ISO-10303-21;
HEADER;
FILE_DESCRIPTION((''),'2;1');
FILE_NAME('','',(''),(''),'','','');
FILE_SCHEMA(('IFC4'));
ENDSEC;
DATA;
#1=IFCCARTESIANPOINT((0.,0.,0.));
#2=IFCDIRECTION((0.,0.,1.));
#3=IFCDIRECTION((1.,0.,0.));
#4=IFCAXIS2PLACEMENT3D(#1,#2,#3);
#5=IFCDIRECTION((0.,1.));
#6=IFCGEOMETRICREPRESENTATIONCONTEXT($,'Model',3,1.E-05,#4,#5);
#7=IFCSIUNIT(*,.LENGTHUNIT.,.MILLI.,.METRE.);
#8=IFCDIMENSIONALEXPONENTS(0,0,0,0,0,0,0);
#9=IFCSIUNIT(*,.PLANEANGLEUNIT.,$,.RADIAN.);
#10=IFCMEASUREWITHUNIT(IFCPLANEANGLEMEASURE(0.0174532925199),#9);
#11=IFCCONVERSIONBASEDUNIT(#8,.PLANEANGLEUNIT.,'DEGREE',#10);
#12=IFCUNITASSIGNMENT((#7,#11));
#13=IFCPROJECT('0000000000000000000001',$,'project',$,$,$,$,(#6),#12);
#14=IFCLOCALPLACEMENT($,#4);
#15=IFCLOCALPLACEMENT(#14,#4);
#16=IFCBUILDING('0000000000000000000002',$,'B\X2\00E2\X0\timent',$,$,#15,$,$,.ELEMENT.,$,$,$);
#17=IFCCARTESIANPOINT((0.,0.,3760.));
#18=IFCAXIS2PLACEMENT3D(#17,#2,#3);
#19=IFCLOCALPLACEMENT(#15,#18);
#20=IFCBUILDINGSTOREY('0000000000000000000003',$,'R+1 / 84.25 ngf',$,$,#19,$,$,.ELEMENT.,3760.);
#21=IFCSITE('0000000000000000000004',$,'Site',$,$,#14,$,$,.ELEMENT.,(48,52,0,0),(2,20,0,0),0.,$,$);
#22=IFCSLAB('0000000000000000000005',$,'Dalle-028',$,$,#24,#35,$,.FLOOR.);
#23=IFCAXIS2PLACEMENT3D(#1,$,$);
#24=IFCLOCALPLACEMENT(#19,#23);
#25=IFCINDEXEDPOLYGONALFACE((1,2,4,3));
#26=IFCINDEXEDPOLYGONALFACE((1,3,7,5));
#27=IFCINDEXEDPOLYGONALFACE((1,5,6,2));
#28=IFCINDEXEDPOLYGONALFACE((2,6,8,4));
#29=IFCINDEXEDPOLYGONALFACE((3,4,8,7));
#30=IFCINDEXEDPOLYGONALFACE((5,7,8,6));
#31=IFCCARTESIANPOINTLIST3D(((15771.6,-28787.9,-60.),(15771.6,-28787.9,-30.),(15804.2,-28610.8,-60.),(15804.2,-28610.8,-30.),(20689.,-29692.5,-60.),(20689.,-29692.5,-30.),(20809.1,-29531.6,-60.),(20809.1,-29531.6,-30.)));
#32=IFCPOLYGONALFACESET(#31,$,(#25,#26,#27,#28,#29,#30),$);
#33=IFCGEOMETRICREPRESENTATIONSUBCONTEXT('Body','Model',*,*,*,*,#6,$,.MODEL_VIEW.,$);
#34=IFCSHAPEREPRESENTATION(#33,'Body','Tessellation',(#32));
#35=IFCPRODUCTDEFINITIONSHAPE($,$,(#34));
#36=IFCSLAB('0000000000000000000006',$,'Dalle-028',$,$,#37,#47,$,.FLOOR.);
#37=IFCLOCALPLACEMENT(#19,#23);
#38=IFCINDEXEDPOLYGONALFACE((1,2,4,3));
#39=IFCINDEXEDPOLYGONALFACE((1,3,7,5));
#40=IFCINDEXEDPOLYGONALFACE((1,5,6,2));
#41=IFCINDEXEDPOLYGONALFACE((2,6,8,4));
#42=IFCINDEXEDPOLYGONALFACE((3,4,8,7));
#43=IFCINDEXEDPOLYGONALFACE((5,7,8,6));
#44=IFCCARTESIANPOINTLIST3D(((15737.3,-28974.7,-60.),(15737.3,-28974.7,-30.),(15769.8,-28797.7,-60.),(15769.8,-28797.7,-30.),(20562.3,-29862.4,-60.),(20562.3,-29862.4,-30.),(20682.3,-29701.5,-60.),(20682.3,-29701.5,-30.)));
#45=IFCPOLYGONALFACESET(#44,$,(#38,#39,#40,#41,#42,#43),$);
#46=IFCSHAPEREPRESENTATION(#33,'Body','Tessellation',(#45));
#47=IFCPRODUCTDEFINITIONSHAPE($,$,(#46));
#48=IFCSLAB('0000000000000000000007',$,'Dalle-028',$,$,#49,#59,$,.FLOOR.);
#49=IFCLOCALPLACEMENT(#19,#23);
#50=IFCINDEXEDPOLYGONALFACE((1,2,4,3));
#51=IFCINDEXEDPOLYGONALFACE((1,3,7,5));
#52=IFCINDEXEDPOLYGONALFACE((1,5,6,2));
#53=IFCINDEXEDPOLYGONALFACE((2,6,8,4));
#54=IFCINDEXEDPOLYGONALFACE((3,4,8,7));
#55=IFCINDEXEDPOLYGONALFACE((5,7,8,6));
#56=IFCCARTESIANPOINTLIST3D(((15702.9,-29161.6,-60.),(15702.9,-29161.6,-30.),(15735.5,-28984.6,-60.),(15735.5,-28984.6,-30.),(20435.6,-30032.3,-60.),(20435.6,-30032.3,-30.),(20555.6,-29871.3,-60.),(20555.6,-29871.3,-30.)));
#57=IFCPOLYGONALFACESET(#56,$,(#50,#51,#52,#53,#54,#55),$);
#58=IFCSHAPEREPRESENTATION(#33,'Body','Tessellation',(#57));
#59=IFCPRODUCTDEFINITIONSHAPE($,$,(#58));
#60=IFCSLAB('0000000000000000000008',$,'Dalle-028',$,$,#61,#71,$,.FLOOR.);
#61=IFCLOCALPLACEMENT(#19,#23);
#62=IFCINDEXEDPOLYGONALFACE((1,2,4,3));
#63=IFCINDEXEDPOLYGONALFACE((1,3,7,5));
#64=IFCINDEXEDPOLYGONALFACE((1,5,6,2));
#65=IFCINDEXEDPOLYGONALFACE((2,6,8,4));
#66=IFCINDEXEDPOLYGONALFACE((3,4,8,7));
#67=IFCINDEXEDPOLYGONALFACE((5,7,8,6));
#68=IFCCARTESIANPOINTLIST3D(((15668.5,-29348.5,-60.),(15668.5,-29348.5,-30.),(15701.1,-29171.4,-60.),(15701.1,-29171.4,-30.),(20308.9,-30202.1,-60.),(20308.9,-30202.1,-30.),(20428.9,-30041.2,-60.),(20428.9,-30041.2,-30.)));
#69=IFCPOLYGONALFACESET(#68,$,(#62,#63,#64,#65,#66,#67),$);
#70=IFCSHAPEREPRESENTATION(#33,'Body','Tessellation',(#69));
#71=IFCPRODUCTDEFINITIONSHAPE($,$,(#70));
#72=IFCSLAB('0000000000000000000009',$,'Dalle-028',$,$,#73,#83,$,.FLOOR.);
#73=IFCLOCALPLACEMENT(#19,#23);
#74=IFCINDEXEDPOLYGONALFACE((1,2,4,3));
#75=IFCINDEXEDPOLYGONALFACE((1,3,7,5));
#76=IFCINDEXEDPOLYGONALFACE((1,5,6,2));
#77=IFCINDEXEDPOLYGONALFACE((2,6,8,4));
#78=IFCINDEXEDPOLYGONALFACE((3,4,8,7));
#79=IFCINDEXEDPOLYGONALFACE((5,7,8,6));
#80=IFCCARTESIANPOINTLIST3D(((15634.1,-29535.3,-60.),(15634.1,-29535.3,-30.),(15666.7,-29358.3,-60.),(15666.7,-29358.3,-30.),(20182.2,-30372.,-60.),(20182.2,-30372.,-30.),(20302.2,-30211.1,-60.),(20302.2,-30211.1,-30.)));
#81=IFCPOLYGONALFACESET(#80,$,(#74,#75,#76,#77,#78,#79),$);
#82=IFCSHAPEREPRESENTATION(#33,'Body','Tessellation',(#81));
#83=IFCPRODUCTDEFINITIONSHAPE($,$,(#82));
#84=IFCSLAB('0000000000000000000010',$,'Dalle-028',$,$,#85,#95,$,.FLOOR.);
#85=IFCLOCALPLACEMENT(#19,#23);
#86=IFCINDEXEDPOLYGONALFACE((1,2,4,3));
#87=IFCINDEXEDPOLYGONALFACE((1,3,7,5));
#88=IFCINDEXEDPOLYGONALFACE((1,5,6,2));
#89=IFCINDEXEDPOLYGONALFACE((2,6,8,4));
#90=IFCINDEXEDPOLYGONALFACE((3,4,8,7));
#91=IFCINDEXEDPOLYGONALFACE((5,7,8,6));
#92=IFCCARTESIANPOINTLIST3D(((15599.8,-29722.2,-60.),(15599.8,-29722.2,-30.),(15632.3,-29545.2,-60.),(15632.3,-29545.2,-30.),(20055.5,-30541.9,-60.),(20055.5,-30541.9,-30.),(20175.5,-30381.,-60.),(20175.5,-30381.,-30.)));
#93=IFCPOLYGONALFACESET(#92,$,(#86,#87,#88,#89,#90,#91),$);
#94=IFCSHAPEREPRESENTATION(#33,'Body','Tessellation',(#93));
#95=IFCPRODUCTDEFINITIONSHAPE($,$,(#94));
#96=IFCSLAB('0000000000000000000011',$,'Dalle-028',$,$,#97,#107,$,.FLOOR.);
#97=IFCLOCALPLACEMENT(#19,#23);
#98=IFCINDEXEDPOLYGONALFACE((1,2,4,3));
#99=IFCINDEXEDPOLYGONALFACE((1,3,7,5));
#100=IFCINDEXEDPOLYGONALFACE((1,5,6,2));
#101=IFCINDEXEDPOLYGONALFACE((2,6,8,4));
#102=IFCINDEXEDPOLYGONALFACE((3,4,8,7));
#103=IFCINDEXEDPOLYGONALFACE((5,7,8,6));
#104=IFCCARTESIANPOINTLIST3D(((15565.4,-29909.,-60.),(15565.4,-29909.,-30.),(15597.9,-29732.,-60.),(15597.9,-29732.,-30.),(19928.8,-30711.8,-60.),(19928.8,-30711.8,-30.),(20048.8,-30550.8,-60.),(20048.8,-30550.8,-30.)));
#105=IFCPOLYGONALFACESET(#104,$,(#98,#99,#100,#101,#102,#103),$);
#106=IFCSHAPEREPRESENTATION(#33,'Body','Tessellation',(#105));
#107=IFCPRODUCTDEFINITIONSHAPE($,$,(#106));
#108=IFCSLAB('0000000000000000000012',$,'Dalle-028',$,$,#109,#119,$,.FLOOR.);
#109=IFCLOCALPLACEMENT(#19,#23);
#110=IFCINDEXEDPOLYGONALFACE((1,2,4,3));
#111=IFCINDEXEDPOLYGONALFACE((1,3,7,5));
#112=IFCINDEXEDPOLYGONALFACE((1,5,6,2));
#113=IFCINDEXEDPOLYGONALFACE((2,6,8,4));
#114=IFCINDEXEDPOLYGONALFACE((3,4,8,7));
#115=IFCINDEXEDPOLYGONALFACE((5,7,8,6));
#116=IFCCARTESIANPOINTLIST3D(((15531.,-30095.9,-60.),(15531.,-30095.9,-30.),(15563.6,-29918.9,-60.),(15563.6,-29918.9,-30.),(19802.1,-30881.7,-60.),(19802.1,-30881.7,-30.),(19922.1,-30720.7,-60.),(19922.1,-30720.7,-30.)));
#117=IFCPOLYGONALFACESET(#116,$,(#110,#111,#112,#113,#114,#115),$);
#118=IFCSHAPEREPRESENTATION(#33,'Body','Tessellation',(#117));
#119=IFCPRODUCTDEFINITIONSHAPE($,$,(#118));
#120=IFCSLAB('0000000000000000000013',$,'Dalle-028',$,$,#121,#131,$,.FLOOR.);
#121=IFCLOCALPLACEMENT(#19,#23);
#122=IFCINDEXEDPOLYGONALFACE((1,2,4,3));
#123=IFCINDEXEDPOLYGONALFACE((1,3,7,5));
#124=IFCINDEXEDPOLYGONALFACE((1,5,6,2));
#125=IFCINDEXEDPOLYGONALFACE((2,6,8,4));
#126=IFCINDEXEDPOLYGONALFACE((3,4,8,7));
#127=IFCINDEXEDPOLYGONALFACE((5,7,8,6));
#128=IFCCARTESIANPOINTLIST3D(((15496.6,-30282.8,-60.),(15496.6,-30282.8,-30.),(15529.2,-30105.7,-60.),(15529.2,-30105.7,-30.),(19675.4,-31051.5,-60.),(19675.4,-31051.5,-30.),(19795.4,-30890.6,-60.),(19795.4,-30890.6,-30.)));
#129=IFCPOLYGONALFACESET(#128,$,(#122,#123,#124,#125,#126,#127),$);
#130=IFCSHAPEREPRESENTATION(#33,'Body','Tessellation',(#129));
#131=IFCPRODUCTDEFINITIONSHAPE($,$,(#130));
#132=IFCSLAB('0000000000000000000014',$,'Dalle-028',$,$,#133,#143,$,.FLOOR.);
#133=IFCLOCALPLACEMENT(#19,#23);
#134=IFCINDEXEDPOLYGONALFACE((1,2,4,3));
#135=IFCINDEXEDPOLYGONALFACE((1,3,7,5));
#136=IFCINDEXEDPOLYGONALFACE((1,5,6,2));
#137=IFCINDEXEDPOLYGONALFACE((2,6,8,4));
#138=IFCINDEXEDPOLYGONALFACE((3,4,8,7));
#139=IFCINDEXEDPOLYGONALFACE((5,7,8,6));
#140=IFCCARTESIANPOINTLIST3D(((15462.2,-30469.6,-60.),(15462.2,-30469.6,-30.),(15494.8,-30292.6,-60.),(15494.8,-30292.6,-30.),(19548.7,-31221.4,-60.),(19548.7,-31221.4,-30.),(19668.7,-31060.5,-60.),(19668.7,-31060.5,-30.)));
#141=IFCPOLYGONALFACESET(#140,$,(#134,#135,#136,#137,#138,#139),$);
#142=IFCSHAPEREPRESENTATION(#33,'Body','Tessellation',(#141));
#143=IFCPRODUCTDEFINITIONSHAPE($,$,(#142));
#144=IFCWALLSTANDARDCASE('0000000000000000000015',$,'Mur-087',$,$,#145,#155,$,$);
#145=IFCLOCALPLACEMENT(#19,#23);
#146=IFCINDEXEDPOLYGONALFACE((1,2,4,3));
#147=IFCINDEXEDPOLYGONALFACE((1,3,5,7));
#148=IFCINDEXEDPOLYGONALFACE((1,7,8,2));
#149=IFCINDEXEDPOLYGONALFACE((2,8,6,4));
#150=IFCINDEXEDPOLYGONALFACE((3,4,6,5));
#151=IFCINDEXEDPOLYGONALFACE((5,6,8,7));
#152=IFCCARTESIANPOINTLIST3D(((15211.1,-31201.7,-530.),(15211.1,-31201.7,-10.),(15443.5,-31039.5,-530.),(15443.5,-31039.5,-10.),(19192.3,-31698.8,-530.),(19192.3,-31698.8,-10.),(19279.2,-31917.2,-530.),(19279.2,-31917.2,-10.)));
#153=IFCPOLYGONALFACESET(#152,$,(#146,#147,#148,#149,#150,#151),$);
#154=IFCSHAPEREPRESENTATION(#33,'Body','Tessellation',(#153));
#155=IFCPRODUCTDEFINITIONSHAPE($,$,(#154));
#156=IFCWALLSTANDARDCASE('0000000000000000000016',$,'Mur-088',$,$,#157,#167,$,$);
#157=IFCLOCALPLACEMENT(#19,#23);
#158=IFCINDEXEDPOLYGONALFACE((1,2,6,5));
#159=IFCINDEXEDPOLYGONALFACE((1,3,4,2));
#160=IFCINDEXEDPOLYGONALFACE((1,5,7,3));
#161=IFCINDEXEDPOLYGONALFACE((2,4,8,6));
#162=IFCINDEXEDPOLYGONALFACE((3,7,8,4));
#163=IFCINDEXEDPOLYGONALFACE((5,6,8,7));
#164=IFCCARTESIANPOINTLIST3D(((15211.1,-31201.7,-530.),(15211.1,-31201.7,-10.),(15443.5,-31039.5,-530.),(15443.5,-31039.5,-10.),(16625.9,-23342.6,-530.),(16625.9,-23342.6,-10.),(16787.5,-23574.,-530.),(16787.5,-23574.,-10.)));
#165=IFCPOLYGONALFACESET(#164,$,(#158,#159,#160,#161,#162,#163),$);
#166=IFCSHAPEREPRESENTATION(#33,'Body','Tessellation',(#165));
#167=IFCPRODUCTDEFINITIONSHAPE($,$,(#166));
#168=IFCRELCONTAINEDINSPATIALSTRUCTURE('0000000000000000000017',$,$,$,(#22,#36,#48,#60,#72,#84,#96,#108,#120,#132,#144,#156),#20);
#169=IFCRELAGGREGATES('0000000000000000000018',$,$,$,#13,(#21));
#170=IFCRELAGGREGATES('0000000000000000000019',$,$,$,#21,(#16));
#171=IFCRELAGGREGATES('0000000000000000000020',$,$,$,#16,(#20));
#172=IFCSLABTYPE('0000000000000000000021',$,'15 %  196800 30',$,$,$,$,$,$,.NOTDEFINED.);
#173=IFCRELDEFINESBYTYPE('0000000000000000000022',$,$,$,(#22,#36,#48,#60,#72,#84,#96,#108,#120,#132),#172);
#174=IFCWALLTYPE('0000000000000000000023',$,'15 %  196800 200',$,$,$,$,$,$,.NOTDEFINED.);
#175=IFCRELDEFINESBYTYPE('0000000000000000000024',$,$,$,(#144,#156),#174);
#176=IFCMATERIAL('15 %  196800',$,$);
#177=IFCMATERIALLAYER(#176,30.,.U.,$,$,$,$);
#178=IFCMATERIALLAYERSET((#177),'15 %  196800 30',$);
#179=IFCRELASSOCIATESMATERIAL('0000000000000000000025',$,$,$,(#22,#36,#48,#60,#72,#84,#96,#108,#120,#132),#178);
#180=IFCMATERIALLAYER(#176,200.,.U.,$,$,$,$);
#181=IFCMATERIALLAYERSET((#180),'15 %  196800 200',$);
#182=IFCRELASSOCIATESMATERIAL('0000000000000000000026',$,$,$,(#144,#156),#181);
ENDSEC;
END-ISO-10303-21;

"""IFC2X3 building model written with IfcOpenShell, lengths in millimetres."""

from ifc_helpers import new_model, entity, si_unit, converted_unit, direction, frame, origin_with_axes, place, context, subcontext, project, spatial, polyline, outline, extrude, material, layer, layer_set, layer_usage, type_object, element, save


model = new_model("IFC2X3")

# Units and contexts
model_context = context("Model", 3, precision=1e-05, world=origin_with_axes(), true_north=direction((0.0, 1.0)))
body_context = subcontext(model_context, "Body", "Model", "MODEL_VIEW")
ifc_project = project(units=[si_unit("LENGTHUNIT", "METRE", prefix="MILLI"), converted_unit("PLANEANGLEUNIT", "DEGREE", entity("IfcPlaneAngleMeasure", 0.0174532925199), si_unit("PLANEANGLEUNIT", "RADIAN"), dimensions=[0, 0, 0, 0, 0, 0, 0])], contexts=[model_context])

# Site, building, storey
site_placement = place(None, origin_with_axes())
site = spatial("IfcSite", under=ifc_project, at=site_placement, Name="Site", CompositionType="ELEMENT", RefLatitude=(48, 52, 0, 0), RefLongitude=(2, 20, 0, 0), RefElevation=0.0)
building_placement = place(site_placement, origin_with_axes())
building = spatial("IfcBuilding", under=site, at=building_placement, Name="Bâtiment", CompositionType="ELEMENT")
storey_placement = place(building_placement, frame((0.0, 0.0, 3760.0), z_axis=(0.0, 0.0, 1.0), x_axis=(1.0, 0.0, 0.0)))
storey = spatial("IfcBuildingStorey", under=building, at=storey_placement, Name="R+1 / 84.25 ngf", CompositionType="ELEMENT", Elevation=3760.0)

# Slabs
ifc_material_1 = material(Name="15 %  196800")
ifc_layer_1 = layer(ifc_material_1, 30.0, ventilated="UNKNOWN")
ifc_layer_set_1 = layer_set([ifc_layer_1], Name="15 %  196800 30")
slab_type = type_object("IfcSlabType", Name="15 %  196800 30", PredefinedType="NOTDEFINED")
ifc_layer_usage_1 = layer_usage(ifc_layer_set_1, "AXIS3", "NEGATIVE", 30.0)
slab_1_placement = place(storey_placement, frame((15804.2, -28610.8, -30.0), z_axis=(0.0, 0.0, 1.0), x_axis=(1.0, 0.0, 0.0)))
element("IfcSlab", 1, at=slab_1_placement, inside=storey, type_object=slab_type, material=ifc_layer_usage_1, Name="Dalle-028", PredefinedType="FLOOR", context=body_context, shape_type="SweptSolid", body=[
    extrude(outline(polyline([(0.0, 0.0), (-32.6, -177.0), (4884.8, -1081.7), (5004.8, -920.7), (0.0, 0.0)])), frame((0.0, 0.0, -30.0), z_axis=(0.0, 0.0, 1.0), x_axis=(1.0, 0.0, 0.0)), (0.0, 0.0, 1.0), 30.0),
])
ifc_layer_usage_2 = layer_usage(ifc_layer_set_1, "AXIS3", "NEGATIVE", 30.0)
slab_2_placement = place(storey_placement, frame((15769.8, -28797.7, -30.0), z_axis=(0.0, 0.0, 1.0), x_axis=(1.0, 0.0, 0.0)))
element("IfcSlab", 2, at=slab_2_placement, inside=storey, type_object=slab_type, material=ifc_layer_usage_2, Name="Dalle-028", PredefinedType="FLOOR", context=body_context, shape_type="SweptSolid", body=[
    extrude(outline(polyline([(0.0, 0.0), (-32.6, -177.0), (4792.5, -1064.7), (4912.5, -903.8), (0.0, 0.0)])), frame((0.0, 0.0, -30.0), z_axis=(0.0, 0.0, 1.0), x_axis=(1.0, 0.0, 0.0)), (0.0, 0.0, 1.0), 30.0),
])
ifc_layer_usage_3 = layer_usage(ifc_layer_set_1, "AXIS3", "NEGATIVE", 30.0)
slab_3_placement = place(storey_placement, frame((15735.5, -28984.6, -30.0), z_axis=(0.0, 0.0, 1.0), x_axis=(1.0, 0.0, 0.0)))
element("IfcSlab", 3, at=slab_3_placement, inside=storey, type_object=slab_type, material=ifc_layer_usage_3, Name="Dalle-028", PredefinedType="FLOOR", context=body_context, shape_type="SweptSolid", body=[
    extrude(outline(polyline([(0.0, 0.0), (-32.6, -177.0), (4700.1, -1047.7), (4820.2, -886.8), (0.0, 0.0)])), frame((0.0, 0.0, -30.0), z_axis=(0.0, 0.0, 1.0), x_axis=(1.0, 0.0, 0.0)), (0.0, 0.0, 1.0), 30.0),
])
ifc_layer_usage_4 = layer_usage(ifc_layer_set_1, "AXIS3", "NEGATIVE", 30.0)
slab_4_placement = place(storey_placement, frame((15701.1, -29171.4, -30.0), z_axis=(0.0, 0.0, 1.0), x_axis=(1.0, 0.0, 0.0)))
element("IfcSlab", 4, at=slab_4_placement, inside=storey, type_object=slab_type, material=ifc_layer_usage_4, Name="Dalle-028", PredefinedType="FLOOR", context=body_context, shape_type="SweptSolid", body=[
    extrude(outline(polyline([(0.0, 0.0), (-32.6, -177.0), (4607.8, -1030.7), (4727.9, -869.8), (0.0, 0.0)])), frame((0.0, 0.0, -30.0), z_axis=(0.0, 0.0, 1.0), x_axis=(1.0, 0.0, 0.0)), (0.0, 0.0, 1.0), 30.0),
])
ifc_layer_usage_5 = layer_usage(ifc_layer_set_1, "AXIS3", "NEGATIVE", 30.0)
slab_5_placement = place(storey_placement, frame((15666.7, -29358.3, -30.0), z_axis=(0.0, 0.0, 1.0), x_axis=(1.0, 0.0, 0.0)))
element("IfcSlab", 5, at=slab_5_placement, inside=storey, type_object=slab_type, material=ifc_layer_usage_5, Name="Dalle-028", PredefinedType="FLOOR", context=body_context, shape_type="SweptSolid", body=[
    extrude(outline(polyline([(0.0, 0.0), (-32.6, -177.0), (4515.5, -1013.7), (4635.5, -852.8), (0.0, 0.0)])), frame((0.0, 0.0, -30.0), z_axis=(0.0, 0.0, 1.0), x_axis=(1.0, 0.0, 0.0)), (0.0, 0.0, 1.0), 30.0),
])
ifc_layer_usage_6 = layer_usage(ifc_layer_set_1, "AXIS3", "NEGATIVE", 30.0)
slab_6_placement = place(storey_placement, frame((15632.3, -29545.2, -30.0), z_axis=(0.0, 0.0, 1.0), x_axis=(1.0, 0.0, 0.0)))
element("IfcSlab", 6, at=slab_6_placement, inside=storey, type_object=slab_type, material=ifc_layer_usage_6, Name="Dalle-028", PredefinedType="FLOOR", context=body_context, shape_type="SweptSolid", body=[
    extrude(outline(polyline([(0.0, 0.0), (-32.6, -177.0), (4423.2, -996.7), (4543.2, -835.8), (0.0, 0.0)])), frame((0.0, 0.0, -30.0), z_axis=(0.0, 0.0, 1.0), x_axis=(1.0, 0.0, 0.0)), (0.0, 0.0, 1.0), 30.0),
])
ifc_layer_usage_7 = layer_usage(ifc_layer_set_1, "AXIS3", "NEGATIVE", 30.0)
slab_7_placement = place(storey_placement, frame((15597.9, -29732.0, -30.0), z_axis=(0.0, 0.0, 1.0), x_axis=(1.0, 0.0, 0.0)))
element("IfcSlab", 7, at=slab_7_placement, inside=storey, type_object=slab_type, material=ifc_layer_usage_7, Name="Dalle-028", PredefinedType="FLOOR", context=body_context, shape_type="SweptSolid", body=[
    extrude(outline(polyline([(0.0, 0.0), (-32.6, -177.0), (4330.8, -979.8), (4450.9, -818.8), (0.0, 0.0)])), frame((0.0, 0.0, -30.0), z_axis=(0.0, 0.0, 1.0), x_axis=(1.0, 0.0, 0.0)), (0.0, 0.0, 1.0), 30.0),
])
ifc_layer_usage_8 = layer_usage(ifc_layer_set_1, "AXIS3", "NEGATIVE", 30.0)
slab_8_placement = place(storey_placement, frame((15563.6, -29918.9, -30.0), z_axis=(0.0, 0.0, 1.0), x_axis=(1.0, 0.0, 0.0)))
element("IfcSlab", 8, at=slab_8_placement, inside=storey, type_object=slab_type, material=ifc_layer_usage_8, Name="Dalle-028", PredefinedType="FLOOR", context=body_context, shape_type="SweptSolid", body=[
    extrude(outline(polyline([(0.0, 0.0), (-32.6, -177.0), (4238.5, -962.8), (4358.5, -801.8), (0.0, 0.0)])), frame((0.0, 0.0, -30.0), z_axis=(0.0, 0.0, 1.0), x_axis=(1.0, 0.0, 0.0)), (0.0, 0.0, 1.0), 30.0),
])
ifc_layer_usage_9 = layer_usage(ifc_layer_set_1, "AXIS3", "NEGATIVE", 30.0)
slab_9_placement = place(storey_placement, frame((15529.2, -30105.7, -30.0), z_axis=(0.0, 0.0, 1.0), x_axis=(1.0, 0.0, 0.0)))
element("IfcSlab", 9, at=slab_9_placement, inside=storey, type_object=slab_type, material=ifc_layer_usage_9, Name="Dalle-028", PredefinedType="FLOOR", context=body_context, shape_type="SweptSolid", body=[
    extrude(outline(polyline([(0.0, 0.0), (-32.6, -177.0), (4146.2, -945.8), (4266.2, -784.8), (0.0, 0.0)])), frame((0.0, 0.0, -30.0), z_axis=(0.0, 0.0, 1.0), x_axis=(1.0, 0.0, 0.0)), (0.0, 0.0, 1.0), 30.0),
])
ifc_layer_usage_10 = layer_usage(ifc_layer_set_1, "AXIS3", "NEGATIVE", 30.0)
slab_10_placement = place(storey_placement, frame((15494.8, -30292.6, -30.0), z_axis=(0.0, 0.0, 1.0), x_axis=(1.0, 0.0, 0.0)))
element("IfcSlab", 10, at=slab_10_placement, inside=storey, type_object=slab_type, material=ifc_layer_usage_10, Name="Dalle-028", PredefinedType="FLOOR", context=body_context, shape_type="SweptSolid", body=[
    extrude(outline(polyline([(0.0, 0.0), (-32.6, -177.0), (4053.8, -928.8), (4173.9, -767.9), (0.0, 0.0)])), frame((0.0, 0.0, -30.0), z_axis=(0.0, 0.0, 1.0), x_axis=(1.0, 0.0, 0.0)), (0.0, 0.0, 1.0), 30.0),
])

# Walls
ifc_layer_2 = layer(ifc_material_1, 200.0, ventilated="UNKNOWN")
ifc_layer_set_2 = layer_set([ifc_layer_2], Name="15 %  196800 200")
ifc_layer_usage_11 = layer_usage(ifc_layer_set_2, "AXIS2", "POSITIVE", -200.0)
wall_type = type_object("IfcWallType", Name="15 %  196800 200", PredefinedType="NOTDEFINED")
wall_1_placement = place(storey_placement, frame((19279.2, -31917.2, -530.0), z_axis=(0.0, 0.0, 1.0), x_axis=(-0.984885, 0.173208, 0.0)))
element("IfcWallStandardCase", 11, at=wall_1_placement, inside=storey, type_object=wall_type, material=ifc_layer_usage_11, Name="Mur-087", context=body_context, shape_type="SweptSolid", body=[
    extrude(outline(polyline([(123.4, -200.0), (3929.7, -200.0), (4130.5, 0.0), (0.0, 0.0), (123.4, -200.0)])), origin_with_axes(), (0.0, 0.0, 1.0), 520.0),
])
ifc_layer_usage_12 = layer_usage(ifc_layer_set_2, "AXIS2", "POSITIVE", -200.0)
wall_2_placement = place(storey_placement, frame((15211.1, -31201.7, -530.0), z_axis=(0.0, 0.0, 1.0), x_axis=(0.177175, 0.984179, 0.0)))
element("IfcWallStandardCase", 12, at=wall_2_placement, inside=storey, type_object=wall_type, material=ifc_layer_usage_12, Name="Mur-088", context=body_context, shape_type="SweptSolid", body=[
    extrude(outline(polyline([(200.8, -200.0), (7786.3, -200.0), (7985.4, 0.0), (0.0, 0.0), (200.8, -200.0)])), origin_with_axes(), (0.0, 0.0, 1.0), 520.0),
])

save(model, "model.ifc")
